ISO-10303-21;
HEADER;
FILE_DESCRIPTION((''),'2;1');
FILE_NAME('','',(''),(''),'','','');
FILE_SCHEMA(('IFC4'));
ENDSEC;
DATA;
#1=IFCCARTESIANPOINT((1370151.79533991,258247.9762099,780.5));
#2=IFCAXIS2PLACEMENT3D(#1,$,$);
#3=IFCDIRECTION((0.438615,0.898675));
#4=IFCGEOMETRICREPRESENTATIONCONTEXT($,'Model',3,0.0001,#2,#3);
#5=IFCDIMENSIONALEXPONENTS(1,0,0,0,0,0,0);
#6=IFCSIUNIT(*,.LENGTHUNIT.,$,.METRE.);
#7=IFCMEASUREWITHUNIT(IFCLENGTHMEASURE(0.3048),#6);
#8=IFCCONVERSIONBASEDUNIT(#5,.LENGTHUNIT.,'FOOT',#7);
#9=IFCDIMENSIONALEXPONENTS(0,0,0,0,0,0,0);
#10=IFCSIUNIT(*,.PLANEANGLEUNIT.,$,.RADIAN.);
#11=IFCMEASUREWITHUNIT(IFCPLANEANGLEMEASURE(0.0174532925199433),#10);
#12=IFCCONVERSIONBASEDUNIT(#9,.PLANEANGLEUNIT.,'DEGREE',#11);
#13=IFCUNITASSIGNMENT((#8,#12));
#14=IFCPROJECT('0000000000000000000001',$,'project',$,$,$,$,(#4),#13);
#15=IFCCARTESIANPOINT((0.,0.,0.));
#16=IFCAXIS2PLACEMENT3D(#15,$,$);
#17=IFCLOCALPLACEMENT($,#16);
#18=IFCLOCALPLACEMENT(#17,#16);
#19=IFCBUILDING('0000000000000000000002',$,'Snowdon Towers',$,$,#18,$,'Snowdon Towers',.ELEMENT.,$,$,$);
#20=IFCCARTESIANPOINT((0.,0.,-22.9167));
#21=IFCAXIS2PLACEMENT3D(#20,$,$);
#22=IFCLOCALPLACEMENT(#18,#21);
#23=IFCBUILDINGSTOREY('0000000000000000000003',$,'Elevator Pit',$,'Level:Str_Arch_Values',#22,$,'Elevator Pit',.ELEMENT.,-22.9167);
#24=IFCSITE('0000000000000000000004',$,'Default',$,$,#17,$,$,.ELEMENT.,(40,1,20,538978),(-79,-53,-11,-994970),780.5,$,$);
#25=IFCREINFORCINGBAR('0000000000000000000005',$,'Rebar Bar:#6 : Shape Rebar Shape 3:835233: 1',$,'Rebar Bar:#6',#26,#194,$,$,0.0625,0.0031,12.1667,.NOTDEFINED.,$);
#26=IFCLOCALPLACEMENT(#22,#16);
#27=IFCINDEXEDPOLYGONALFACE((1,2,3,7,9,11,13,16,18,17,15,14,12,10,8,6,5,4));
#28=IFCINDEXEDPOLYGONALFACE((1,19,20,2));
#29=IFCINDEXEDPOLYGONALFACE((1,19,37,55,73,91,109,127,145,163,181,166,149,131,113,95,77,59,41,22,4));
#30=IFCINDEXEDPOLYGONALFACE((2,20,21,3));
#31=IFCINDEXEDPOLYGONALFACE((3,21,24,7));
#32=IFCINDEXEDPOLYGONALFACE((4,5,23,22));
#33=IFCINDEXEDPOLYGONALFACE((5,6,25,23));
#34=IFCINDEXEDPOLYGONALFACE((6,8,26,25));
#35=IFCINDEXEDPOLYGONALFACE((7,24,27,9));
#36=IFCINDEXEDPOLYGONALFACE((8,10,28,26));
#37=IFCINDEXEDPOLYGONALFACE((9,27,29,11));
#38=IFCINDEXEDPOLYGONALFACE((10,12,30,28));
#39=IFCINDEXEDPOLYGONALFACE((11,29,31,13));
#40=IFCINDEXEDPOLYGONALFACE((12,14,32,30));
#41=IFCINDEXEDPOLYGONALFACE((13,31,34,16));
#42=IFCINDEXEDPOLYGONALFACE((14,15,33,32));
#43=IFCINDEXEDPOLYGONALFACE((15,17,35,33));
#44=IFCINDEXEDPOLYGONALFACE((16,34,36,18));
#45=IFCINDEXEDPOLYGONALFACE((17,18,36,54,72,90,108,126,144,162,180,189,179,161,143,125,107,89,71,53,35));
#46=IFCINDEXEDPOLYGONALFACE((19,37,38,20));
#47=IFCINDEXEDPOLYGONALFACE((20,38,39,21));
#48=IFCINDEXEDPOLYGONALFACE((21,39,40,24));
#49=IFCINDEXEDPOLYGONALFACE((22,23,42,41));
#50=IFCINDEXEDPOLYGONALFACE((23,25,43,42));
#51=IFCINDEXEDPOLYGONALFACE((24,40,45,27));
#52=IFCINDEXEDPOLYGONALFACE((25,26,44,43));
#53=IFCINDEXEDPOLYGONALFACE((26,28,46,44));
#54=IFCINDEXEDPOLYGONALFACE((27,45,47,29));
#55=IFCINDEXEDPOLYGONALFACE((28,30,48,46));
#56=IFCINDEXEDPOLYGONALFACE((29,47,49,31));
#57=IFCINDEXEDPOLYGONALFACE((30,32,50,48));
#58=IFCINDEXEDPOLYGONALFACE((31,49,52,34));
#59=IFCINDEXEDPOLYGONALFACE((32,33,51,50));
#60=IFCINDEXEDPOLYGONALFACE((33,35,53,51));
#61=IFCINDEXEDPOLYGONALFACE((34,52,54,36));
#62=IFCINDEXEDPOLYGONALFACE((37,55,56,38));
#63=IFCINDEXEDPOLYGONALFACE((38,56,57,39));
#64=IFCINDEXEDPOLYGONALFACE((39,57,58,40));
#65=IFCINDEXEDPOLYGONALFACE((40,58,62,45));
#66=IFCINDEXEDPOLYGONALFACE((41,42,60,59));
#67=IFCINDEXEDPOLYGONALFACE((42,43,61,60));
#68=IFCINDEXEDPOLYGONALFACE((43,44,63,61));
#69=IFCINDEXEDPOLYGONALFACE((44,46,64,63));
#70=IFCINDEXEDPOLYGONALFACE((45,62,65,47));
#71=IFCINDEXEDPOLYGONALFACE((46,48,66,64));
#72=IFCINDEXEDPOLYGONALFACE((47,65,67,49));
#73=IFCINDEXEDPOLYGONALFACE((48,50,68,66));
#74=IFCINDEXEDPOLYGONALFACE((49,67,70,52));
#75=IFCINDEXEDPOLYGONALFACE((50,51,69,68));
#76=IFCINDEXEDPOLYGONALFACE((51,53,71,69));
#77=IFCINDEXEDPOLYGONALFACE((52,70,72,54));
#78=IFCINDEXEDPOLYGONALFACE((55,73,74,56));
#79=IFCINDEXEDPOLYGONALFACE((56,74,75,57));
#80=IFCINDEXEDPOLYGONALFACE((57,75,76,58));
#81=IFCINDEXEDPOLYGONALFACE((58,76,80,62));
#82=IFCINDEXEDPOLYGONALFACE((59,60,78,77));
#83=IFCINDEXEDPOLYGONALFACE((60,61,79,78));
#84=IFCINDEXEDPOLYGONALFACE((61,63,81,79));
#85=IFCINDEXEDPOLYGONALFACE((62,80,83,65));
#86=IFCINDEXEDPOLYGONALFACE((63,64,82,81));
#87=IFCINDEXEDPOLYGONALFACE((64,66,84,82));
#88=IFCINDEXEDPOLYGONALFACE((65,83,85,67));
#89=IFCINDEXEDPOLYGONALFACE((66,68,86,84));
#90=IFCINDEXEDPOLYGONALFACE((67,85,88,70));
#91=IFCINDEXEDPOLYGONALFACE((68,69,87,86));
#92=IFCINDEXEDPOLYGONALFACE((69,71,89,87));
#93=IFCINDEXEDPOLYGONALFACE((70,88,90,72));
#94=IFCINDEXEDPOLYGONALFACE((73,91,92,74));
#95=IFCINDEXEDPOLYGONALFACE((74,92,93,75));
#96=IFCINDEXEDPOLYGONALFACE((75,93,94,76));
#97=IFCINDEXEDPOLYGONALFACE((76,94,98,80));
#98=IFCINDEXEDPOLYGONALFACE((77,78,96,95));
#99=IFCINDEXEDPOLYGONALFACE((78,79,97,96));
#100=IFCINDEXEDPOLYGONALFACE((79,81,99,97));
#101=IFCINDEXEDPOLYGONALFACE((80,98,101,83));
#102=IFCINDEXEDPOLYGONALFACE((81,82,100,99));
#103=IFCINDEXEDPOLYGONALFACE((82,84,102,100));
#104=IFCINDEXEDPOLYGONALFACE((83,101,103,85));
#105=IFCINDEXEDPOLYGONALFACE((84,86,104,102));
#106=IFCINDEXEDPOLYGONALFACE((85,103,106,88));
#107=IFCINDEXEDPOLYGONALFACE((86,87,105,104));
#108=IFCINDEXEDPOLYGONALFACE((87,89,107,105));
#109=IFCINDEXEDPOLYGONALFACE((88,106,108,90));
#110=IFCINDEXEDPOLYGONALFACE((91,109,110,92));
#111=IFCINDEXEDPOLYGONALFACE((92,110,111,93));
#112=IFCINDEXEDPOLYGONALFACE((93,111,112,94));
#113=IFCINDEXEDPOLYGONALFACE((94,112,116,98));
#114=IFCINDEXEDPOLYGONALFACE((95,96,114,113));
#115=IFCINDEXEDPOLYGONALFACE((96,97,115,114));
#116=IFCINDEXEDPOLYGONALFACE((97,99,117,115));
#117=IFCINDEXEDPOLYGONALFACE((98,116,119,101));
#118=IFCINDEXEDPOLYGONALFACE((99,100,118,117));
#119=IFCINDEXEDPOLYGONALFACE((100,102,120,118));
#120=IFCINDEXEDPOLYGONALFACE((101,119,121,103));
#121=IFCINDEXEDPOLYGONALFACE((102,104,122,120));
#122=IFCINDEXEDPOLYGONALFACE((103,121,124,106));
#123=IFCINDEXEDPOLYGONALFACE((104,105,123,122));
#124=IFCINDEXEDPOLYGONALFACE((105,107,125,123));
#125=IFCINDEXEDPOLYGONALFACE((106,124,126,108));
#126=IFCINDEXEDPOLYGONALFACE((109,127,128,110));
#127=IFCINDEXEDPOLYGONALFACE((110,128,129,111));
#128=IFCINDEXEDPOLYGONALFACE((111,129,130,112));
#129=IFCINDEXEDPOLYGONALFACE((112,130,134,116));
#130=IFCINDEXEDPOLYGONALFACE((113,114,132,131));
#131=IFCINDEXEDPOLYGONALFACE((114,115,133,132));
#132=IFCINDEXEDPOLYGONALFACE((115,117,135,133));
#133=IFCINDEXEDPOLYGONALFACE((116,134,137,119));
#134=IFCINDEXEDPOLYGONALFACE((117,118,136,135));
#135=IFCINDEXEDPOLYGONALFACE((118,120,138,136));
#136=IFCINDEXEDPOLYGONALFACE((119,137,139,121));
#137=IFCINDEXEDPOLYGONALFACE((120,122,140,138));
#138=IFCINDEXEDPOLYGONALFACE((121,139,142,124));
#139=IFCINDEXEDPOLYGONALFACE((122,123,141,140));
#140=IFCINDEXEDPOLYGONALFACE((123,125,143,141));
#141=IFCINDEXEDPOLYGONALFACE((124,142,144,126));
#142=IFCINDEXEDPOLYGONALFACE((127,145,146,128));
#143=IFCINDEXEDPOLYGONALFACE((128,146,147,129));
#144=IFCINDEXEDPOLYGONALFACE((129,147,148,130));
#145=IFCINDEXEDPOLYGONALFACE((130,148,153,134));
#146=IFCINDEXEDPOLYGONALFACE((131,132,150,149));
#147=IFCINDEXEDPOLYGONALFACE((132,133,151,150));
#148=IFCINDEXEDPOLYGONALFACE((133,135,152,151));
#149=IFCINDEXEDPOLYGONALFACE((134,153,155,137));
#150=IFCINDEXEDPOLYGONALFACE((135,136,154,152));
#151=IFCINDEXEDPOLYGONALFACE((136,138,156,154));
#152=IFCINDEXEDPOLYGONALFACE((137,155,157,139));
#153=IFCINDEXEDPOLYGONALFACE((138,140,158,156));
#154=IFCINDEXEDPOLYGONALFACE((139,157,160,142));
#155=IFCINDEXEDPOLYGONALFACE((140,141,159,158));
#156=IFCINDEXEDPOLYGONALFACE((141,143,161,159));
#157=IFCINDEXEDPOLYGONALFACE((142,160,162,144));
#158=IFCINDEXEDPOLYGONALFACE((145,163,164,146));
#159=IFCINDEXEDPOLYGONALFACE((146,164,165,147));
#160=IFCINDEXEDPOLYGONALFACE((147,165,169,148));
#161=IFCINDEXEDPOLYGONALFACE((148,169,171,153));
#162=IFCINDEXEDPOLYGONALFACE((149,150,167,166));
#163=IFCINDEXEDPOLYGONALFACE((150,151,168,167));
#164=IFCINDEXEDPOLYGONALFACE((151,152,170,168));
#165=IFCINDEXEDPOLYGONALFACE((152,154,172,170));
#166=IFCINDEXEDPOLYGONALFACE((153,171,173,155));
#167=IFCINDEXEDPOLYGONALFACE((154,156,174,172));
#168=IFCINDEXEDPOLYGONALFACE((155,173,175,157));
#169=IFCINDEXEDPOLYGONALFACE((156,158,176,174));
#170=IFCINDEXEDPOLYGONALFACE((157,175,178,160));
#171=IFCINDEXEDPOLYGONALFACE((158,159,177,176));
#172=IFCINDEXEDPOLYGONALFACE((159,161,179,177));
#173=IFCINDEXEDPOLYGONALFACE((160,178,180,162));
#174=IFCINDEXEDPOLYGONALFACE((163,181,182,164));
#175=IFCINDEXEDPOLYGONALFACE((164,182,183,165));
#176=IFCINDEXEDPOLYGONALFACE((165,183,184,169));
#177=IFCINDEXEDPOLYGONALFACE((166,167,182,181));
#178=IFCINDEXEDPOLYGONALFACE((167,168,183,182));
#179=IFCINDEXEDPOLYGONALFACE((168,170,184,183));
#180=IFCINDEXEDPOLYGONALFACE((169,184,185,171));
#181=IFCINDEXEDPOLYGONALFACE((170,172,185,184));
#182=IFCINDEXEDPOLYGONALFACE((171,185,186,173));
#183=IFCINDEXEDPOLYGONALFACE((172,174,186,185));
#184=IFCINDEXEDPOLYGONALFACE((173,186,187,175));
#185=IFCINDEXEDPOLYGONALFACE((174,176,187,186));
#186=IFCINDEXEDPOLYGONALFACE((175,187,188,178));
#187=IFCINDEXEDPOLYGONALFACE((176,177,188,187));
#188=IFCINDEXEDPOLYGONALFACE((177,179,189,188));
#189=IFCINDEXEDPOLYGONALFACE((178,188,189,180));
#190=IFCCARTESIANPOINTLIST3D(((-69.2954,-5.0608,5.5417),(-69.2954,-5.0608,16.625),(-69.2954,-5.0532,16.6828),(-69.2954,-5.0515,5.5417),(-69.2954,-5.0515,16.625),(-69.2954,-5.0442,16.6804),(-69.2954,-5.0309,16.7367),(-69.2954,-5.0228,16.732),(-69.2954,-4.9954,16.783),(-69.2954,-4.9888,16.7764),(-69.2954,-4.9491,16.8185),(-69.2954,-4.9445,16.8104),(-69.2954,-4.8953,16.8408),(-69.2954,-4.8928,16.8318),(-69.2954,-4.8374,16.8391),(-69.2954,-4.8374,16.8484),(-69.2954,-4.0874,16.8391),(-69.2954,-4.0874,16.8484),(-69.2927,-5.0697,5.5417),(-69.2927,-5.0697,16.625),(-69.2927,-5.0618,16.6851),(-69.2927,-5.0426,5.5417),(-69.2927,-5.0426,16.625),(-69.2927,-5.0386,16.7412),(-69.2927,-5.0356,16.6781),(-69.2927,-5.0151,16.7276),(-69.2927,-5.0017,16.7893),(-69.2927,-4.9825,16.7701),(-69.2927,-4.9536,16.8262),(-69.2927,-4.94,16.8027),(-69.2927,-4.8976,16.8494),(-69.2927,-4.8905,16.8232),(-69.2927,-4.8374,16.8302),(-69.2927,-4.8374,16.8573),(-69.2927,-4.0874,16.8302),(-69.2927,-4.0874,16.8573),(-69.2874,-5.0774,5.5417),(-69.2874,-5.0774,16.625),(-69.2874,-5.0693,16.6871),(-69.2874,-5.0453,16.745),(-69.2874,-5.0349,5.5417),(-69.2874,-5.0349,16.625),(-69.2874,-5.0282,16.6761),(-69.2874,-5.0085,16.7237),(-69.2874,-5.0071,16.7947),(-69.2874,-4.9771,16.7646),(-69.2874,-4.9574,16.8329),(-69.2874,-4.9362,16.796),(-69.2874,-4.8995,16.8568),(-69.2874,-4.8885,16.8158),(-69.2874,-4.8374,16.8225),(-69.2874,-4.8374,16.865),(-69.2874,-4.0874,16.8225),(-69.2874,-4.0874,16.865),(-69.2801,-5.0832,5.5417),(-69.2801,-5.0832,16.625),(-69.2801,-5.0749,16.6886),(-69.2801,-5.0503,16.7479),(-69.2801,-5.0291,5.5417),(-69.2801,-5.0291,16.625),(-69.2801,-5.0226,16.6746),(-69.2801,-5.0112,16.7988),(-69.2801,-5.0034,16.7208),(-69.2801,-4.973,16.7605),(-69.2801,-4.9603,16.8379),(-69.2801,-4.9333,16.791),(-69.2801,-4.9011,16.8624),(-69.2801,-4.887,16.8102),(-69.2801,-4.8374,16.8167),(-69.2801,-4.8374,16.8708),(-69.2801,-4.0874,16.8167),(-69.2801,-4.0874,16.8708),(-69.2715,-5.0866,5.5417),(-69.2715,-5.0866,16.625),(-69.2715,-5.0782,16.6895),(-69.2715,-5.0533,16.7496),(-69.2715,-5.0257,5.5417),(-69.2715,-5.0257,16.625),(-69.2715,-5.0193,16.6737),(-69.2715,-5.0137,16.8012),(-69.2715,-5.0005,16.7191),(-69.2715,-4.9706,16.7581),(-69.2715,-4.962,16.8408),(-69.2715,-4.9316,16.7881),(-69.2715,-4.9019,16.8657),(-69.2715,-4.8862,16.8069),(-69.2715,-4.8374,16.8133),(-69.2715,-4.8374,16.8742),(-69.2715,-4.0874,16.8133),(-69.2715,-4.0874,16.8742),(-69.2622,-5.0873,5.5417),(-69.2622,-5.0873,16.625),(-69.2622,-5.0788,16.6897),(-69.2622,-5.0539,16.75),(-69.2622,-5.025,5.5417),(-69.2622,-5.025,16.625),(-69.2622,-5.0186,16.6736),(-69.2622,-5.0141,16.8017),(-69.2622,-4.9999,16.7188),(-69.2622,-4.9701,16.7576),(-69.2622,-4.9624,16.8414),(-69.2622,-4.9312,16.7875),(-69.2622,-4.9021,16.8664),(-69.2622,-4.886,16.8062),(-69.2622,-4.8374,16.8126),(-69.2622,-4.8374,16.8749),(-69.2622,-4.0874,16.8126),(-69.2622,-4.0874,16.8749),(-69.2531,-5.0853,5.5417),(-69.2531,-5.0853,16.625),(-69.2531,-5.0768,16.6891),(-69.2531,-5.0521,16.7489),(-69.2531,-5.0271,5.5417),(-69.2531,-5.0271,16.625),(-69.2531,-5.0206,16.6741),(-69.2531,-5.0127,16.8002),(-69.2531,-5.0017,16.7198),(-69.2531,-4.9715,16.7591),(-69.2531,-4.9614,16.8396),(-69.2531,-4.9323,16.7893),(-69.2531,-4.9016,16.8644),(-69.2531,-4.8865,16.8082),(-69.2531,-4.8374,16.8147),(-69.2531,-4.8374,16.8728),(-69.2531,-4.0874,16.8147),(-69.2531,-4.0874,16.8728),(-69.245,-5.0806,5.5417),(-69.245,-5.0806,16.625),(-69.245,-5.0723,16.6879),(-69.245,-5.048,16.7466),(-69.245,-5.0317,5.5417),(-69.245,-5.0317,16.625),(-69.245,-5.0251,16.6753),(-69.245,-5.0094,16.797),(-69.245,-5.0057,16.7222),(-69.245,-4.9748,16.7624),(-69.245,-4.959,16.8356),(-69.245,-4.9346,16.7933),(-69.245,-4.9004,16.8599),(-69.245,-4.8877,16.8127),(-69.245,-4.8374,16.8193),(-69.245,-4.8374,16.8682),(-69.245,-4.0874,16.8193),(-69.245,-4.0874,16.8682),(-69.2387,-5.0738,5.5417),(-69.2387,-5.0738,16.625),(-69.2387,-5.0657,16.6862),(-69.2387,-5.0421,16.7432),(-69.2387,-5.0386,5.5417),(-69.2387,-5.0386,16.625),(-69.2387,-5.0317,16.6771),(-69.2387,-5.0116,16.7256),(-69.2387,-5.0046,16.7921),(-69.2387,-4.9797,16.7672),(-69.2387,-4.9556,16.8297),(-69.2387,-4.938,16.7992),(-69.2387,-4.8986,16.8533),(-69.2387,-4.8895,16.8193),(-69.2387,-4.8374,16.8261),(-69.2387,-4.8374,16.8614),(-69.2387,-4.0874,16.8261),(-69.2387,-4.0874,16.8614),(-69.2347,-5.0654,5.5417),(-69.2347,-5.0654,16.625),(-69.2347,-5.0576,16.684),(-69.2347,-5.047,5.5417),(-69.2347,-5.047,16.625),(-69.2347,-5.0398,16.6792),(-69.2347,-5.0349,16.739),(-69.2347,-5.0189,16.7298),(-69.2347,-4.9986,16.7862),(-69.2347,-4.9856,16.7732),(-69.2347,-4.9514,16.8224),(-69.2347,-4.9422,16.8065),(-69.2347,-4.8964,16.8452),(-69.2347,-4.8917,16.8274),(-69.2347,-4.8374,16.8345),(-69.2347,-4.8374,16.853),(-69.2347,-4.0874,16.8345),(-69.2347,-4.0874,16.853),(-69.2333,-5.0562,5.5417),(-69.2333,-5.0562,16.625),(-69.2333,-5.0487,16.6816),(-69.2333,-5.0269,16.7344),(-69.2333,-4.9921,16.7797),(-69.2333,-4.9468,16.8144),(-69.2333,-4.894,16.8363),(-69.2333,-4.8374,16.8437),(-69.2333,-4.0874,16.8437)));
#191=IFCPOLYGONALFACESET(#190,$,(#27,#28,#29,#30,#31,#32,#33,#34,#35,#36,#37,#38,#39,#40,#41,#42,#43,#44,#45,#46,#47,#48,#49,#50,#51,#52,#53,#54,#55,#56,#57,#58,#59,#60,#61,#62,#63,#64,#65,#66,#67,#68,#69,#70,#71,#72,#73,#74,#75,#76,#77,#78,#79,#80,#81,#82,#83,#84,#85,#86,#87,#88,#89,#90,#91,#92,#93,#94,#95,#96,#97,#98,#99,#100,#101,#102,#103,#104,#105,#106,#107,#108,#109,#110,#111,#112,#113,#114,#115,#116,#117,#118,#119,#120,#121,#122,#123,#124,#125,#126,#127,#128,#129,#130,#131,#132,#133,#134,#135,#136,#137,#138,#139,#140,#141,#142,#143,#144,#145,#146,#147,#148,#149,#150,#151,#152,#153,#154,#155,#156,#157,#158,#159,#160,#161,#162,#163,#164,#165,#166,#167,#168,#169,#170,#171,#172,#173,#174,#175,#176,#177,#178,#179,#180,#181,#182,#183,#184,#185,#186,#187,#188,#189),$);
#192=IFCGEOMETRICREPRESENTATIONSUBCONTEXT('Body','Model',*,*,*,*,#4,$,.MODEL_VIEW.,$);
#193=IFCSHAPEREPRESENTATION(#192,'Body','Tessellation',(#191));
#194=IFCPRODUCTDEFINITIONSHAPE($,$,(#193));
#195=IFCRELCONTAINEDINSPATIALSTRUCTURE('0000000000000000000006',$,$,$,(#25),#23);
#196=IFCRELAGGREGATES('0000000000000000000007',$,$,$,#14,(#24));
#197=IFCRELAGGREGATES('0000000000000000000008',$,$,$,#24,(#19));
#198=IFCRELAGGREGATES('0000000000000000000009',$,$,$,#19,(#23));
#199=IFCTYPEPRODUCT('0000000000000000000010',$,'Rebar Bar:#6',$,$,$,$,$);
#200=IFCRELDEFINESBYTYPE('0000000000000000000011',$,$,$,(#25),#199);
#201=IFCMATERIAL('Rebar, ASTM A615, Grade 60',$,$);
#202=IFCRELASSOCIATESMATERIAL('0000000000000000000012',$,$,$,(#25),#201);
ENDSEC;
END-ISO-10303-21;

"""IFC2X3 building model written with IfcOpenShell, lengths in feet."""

from ifc_helpers import new_model, entity, si_unit, converted_unit, direction, frame, origin, place, context, subcontext, project, spatial, material, type_object, element, save


model = new_model("IFC2X3")

# Units and contexts
model_context = context("Model", 3, precision=0.0001, world=frame((1370151.79533991, 258247.9762099, 780.5)), true_north=direction((0.438615, 0.898675)))
body_context = subcontext(model_context, "Body", "Model", "MODEL_VIEW")
ifc_project = project(units=[converted_unit("LENGTHUNIT", "FOOT", entity("IfcLengthMeasure", 0.3048), si_unit("LENGTHUNIT", "METRE"), dimensions=[1, 0, 0, 0, 0, 0, 0]), converted_unit("PLANEANGLEUNIT", "DEGREE", entity("IfcPlaneAngleMeasure", 0.0174532925199433), si_unit("PLANEANGLEUNIT", "RADIAN"), dimensions=[0, 0, 0, 0, 0, 0, 0])], contexts=[model_context])

# Site, building, storey
site_placement = place(None, origin())
site = spatial("IfcSite", under=ifc_project, at=site_placement, Name="Default", CompositionType="ELEMENT", RefLatitude=(40, 1, 20, 538978), RefLongitude=(-79, -53, -11, -994970), RefElevation=780.5)
building_placement = place(site_placement, origin())
building = spatial("IfcBuilding", under=site, at=building_placement, Name="Snowdon Towers", LongName="Snowdon Towers", CompositionType="ELEMENT")
storey_placement = place(building_placement, frame((0.0, 0.0, -22.9167)))
storey = spatial("IfcBuildingStorey", under=building, at=storey_placement, Name="Elevator Pit", ObjectType="Level:Str_Arch_Values", LongName="Elevator Pit", CompositionType="ELEMENT", Elevation=-22.9167)

# Reinforcing bar
ifc_material_1 = material(Name="Rebar, ASTM A615, Grade 60")
type_product = type_object("IfcTypeProduct", Name="Rebar Bar:#6")
reinforcing_bar_1_placement = place(storey_placement, origin())
element("IfcReinforcingBar", 1, at=reinforcing_bar_1_placement, inside=storey, type_object=type_product, material=ifc_material_1, Name="Rebar Bar:#6 : Shape Rebar Shape 3:835233: 1", ObjectType="Rebar Bar:#6", BarLength=12.1667, BarRole="NOTDEFINED", CrossSectionArea=0.0031, NominalDiameter=0.0625, context=body_context, shape_type="AdvancedSweptSolid", body=[
    entity("IfcSweptDiskSolid", entity("IfcCompositeCurve", [entity("IfcCompositeCurveSegment", "CONTINUOUS", True, entity("IfcPolyline", [entity("IfcCartesianPoint", [-69.2645, -5.0562, 5.5417]), entity("IfcCartesianPoint", [-69.2645, -5.0562, 16.625])])), entity("IfcCompositeCurveSegment", "CONTINUOUS", True, entity("IfcTrimmedCurve", entity("IfcCircle", entity("IfcAxis2Placement3D", entity("IfcCartesianPoint", [-69.2645, -4.8374, 16.625]), entity("IfcDirection", [-1.0, 0.0, 0.0]), entity("IfcDirection", [0.0, 0.0, 1.0])), 0.2188), [entity("IfcParameterValue", 270.0)], [entity("IfcParameterValue", 360.0)], True, "PARAMETER")), entity("IfcCompositeCurveSegment", "CONTINUOUS", True, entity("IfcPolyline", [entity("IfcCartesianPoint", [-69.2645, -4.8374, 16.8437]), entity("IfcCartesianPoint", [-69.2645, -4.0874, 16.8437])]))], False), 0.0312, None, 0.0, 92.0),
])

save(model, "model.ifc")
